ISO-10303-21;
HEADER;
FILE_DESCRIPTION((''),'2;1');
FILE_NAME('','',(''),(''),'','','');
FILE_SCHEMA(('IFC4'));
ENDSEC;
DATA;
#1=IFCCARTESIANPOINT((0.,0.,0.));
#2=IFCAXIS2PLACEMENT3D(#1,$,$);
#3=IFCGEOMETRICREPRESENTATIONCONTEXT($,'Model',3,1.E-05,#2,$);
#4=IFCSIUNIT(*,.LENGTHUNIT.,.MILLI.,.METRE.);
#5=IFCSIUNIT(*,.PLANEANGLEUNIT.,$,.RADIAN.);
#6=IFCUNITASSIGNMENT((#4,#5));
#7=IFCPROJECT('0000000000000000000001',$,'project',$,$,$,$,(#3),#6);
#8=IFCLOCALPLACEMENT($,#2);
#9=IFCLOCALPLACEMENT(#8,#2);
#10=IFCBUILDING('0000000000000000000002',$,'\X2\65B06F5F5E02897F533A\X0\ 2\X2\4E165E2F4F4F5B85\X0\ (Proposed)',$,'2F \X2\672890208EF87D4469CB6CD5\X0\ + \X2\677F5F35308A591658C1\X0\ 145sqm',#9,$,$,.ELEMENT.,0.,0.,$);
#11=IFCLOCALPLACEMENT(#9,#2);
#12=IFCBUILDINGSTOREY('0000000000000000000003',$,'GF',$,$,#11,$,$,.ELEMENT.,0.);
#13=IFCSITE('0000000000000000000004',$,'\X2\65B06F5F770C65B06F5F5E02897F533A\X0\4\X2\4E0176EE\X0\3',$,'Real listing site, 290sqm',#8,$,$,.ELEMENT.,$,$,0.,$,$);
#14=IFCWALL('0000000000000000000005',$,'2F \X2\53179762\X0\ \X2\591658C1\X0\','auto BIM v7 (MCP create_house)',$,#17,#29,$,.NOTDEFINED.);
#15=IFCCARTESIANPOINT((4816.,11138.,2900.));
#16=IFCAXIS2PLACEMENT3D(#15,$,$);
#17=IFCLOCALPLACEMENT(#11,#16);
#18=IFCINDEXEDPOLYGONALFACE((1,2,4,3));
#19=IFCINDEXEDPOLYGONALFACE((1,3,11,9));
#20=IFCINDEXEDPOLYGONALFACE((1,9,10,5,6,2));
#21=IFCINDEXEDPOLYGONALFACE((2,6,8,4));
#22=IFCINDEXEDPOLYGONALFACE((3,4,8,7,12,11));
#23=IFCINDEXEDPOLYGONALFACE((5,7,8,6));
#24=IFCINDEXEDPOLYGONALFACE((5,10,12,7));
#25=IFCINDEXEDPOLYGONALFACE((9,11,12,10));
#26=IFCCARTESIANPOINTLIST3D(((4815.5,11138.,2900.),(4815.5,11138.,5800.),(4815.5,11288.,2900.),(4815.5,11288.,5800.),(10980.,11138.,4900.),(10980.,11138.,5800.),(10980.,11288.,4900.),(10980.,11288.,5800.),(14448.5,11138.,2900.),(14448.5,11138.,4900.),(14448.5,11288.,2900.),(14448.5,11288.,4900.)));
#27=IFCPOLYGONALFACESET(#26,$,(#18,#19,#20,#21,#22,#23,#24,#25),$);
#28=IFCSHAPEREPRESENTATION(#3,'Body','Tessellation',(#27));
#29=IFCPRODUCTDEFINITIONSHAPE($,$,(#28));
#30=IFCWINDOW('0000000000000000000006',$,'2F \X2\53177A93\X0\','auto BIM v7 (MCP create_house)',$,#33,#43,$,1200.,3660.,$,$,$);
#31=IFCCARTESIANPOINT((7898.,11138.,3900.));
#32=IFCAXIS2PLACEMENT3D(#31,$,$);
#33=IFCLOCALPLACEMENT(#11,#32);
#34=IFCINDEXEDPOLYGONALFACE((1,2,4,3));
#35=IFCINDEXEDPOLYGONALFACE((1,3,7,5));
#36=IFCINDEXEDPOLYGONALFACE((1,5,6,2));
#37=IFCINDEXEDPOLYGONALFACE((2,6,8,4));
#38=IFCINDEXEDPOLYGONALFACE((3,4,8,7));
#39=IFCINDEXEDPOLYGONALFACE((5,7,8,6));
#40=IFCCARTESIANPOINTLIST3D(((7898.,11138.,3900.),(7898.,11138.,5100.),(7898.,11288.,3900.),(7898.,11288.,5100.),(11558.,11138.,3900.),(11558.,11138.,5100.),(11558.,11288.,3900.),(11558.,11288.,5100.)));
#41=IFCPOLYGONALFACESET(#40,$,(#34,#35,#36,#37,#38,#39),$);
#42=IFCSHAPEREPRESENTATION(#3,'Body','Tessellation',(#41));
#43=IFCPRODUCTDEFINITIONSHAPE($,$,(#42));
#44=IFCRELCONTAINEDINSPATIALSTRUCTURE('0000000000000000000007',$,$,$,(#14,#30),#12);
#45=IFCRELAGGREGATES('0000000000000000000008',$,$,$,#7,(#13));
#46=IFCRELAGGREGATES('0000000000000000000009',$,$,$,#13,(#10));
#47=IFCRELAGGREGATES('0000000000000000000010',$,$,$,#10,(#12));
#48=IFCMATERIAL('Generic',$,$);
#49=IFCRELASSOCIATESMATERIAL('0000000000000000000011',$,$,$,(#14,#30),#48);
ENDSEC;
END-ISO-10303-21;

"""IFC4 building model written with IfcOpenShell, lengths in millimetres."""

from ifc_helpers import new_model, si_unit, frame, frame_2d, origin, place, context, project, spatial, rectangle, extrude, material, element, fill, save


model = new_model("IFC4")

# Units and contexts
model_context = context("Model", 3, precision=1e-05, world=origin())
ifc_project = project(units=[si_unit("LENGTHUNIT", "METRE", prefix="MILLI"), si_unit("PLANEANGLEUNIT", "RADIAN")], contexts=[model_context])

# Site, building, storey
site_placement = place(None, origin())
site = spatial("IfcSite", under=ifc_project, at=site_placement, Name="新潟県新潟市西区4丁目3", ObjectType="Real listing site, 290sqm", CompositionType="ELEMENT", RefElevation=0.0)
building_placement = place(site_placement, origin())
building = spatial("IfcBuilding", under=site, at=building_placement, Name="新潟市西区 2世帯住宅 (Proposed)", ObjectType="2F 木造軸組構法 + 板張り外壁 145sqm", CompositionType="ELEMENT", ElevationOfRefHeight=0.0, ElevationOfTerrain=0.0)
storey_placement = place(building_placement, origin())
storey = spatial("IfcBuildingStorey", under=building, at=storey_placement, Name="GF", CompositionType="ELEMENT", Elevation=0.0)

# Shared definitions
ifc_material = material(Name="Generic")

# Wall, opening, window
wall_1_placement = place(storey_placement, frame((4816.0, 11138.0, 2900.0)))
wall_1 = element("IfcWall", 1, at=wall_1_placement, inside=storey, material=ifc_material, Name="2F 北面 外壁", Description="auto BIM v7 (MCP create_house)", PredefinedType="NOTDEFINED", context=model_context, shape_type="SweptSolid", body=[
    extrude(rectangle(XDim=9633.0, YDim=150.0, at=frame_2d((4816.0, 75.0))), frame((4816.0, 11138.0, 2900.0)), (0.0, 0.0, 1.0), 2900.0),
])
opening_1_placement = place(storey_placement, frame((7898.0, 11138.0, 3900.0)))
opening_1 = element("IfcOpeningElement", 2, at=opening_1_placement, cuts=wall_1, PredefinedType="NOTDEFINED", context=model_context, shape_type="SweptSolid", body=[
    extrude(rectangle(XDim=3660.0, YDim=150.0, at=frame_2d((1830.0, 75.0))), frame((7898.0, 11138.0, 3900.0)), (0.0, 0.0, 1.0), 1200.0),
])
window_1_placement = place(storey_placement, frame((7898.0, 11138.0, 3900.0)))
window_1 = element("IfcWindow", 3, at=window_1_placement, inside=storey, material=ifc_material, Name="2F 北窓", Description="auto BIM v7 (MCP create_house)", OverallHeight=1200.0, OverallWidth=3660.0, context=model_context, shape_type="SweptSolid", body=[
    extrude(rectangle(XDim=3660.0, YDim=150.0, at=frame_2d((1830.0, 75.0))), frame((7898.0, 11138.0, 3900.0)), (0.0, 0.0, 1.0), 1200.0),
])
fill(opening_1, window_1)

save(model, "model.ifc")
